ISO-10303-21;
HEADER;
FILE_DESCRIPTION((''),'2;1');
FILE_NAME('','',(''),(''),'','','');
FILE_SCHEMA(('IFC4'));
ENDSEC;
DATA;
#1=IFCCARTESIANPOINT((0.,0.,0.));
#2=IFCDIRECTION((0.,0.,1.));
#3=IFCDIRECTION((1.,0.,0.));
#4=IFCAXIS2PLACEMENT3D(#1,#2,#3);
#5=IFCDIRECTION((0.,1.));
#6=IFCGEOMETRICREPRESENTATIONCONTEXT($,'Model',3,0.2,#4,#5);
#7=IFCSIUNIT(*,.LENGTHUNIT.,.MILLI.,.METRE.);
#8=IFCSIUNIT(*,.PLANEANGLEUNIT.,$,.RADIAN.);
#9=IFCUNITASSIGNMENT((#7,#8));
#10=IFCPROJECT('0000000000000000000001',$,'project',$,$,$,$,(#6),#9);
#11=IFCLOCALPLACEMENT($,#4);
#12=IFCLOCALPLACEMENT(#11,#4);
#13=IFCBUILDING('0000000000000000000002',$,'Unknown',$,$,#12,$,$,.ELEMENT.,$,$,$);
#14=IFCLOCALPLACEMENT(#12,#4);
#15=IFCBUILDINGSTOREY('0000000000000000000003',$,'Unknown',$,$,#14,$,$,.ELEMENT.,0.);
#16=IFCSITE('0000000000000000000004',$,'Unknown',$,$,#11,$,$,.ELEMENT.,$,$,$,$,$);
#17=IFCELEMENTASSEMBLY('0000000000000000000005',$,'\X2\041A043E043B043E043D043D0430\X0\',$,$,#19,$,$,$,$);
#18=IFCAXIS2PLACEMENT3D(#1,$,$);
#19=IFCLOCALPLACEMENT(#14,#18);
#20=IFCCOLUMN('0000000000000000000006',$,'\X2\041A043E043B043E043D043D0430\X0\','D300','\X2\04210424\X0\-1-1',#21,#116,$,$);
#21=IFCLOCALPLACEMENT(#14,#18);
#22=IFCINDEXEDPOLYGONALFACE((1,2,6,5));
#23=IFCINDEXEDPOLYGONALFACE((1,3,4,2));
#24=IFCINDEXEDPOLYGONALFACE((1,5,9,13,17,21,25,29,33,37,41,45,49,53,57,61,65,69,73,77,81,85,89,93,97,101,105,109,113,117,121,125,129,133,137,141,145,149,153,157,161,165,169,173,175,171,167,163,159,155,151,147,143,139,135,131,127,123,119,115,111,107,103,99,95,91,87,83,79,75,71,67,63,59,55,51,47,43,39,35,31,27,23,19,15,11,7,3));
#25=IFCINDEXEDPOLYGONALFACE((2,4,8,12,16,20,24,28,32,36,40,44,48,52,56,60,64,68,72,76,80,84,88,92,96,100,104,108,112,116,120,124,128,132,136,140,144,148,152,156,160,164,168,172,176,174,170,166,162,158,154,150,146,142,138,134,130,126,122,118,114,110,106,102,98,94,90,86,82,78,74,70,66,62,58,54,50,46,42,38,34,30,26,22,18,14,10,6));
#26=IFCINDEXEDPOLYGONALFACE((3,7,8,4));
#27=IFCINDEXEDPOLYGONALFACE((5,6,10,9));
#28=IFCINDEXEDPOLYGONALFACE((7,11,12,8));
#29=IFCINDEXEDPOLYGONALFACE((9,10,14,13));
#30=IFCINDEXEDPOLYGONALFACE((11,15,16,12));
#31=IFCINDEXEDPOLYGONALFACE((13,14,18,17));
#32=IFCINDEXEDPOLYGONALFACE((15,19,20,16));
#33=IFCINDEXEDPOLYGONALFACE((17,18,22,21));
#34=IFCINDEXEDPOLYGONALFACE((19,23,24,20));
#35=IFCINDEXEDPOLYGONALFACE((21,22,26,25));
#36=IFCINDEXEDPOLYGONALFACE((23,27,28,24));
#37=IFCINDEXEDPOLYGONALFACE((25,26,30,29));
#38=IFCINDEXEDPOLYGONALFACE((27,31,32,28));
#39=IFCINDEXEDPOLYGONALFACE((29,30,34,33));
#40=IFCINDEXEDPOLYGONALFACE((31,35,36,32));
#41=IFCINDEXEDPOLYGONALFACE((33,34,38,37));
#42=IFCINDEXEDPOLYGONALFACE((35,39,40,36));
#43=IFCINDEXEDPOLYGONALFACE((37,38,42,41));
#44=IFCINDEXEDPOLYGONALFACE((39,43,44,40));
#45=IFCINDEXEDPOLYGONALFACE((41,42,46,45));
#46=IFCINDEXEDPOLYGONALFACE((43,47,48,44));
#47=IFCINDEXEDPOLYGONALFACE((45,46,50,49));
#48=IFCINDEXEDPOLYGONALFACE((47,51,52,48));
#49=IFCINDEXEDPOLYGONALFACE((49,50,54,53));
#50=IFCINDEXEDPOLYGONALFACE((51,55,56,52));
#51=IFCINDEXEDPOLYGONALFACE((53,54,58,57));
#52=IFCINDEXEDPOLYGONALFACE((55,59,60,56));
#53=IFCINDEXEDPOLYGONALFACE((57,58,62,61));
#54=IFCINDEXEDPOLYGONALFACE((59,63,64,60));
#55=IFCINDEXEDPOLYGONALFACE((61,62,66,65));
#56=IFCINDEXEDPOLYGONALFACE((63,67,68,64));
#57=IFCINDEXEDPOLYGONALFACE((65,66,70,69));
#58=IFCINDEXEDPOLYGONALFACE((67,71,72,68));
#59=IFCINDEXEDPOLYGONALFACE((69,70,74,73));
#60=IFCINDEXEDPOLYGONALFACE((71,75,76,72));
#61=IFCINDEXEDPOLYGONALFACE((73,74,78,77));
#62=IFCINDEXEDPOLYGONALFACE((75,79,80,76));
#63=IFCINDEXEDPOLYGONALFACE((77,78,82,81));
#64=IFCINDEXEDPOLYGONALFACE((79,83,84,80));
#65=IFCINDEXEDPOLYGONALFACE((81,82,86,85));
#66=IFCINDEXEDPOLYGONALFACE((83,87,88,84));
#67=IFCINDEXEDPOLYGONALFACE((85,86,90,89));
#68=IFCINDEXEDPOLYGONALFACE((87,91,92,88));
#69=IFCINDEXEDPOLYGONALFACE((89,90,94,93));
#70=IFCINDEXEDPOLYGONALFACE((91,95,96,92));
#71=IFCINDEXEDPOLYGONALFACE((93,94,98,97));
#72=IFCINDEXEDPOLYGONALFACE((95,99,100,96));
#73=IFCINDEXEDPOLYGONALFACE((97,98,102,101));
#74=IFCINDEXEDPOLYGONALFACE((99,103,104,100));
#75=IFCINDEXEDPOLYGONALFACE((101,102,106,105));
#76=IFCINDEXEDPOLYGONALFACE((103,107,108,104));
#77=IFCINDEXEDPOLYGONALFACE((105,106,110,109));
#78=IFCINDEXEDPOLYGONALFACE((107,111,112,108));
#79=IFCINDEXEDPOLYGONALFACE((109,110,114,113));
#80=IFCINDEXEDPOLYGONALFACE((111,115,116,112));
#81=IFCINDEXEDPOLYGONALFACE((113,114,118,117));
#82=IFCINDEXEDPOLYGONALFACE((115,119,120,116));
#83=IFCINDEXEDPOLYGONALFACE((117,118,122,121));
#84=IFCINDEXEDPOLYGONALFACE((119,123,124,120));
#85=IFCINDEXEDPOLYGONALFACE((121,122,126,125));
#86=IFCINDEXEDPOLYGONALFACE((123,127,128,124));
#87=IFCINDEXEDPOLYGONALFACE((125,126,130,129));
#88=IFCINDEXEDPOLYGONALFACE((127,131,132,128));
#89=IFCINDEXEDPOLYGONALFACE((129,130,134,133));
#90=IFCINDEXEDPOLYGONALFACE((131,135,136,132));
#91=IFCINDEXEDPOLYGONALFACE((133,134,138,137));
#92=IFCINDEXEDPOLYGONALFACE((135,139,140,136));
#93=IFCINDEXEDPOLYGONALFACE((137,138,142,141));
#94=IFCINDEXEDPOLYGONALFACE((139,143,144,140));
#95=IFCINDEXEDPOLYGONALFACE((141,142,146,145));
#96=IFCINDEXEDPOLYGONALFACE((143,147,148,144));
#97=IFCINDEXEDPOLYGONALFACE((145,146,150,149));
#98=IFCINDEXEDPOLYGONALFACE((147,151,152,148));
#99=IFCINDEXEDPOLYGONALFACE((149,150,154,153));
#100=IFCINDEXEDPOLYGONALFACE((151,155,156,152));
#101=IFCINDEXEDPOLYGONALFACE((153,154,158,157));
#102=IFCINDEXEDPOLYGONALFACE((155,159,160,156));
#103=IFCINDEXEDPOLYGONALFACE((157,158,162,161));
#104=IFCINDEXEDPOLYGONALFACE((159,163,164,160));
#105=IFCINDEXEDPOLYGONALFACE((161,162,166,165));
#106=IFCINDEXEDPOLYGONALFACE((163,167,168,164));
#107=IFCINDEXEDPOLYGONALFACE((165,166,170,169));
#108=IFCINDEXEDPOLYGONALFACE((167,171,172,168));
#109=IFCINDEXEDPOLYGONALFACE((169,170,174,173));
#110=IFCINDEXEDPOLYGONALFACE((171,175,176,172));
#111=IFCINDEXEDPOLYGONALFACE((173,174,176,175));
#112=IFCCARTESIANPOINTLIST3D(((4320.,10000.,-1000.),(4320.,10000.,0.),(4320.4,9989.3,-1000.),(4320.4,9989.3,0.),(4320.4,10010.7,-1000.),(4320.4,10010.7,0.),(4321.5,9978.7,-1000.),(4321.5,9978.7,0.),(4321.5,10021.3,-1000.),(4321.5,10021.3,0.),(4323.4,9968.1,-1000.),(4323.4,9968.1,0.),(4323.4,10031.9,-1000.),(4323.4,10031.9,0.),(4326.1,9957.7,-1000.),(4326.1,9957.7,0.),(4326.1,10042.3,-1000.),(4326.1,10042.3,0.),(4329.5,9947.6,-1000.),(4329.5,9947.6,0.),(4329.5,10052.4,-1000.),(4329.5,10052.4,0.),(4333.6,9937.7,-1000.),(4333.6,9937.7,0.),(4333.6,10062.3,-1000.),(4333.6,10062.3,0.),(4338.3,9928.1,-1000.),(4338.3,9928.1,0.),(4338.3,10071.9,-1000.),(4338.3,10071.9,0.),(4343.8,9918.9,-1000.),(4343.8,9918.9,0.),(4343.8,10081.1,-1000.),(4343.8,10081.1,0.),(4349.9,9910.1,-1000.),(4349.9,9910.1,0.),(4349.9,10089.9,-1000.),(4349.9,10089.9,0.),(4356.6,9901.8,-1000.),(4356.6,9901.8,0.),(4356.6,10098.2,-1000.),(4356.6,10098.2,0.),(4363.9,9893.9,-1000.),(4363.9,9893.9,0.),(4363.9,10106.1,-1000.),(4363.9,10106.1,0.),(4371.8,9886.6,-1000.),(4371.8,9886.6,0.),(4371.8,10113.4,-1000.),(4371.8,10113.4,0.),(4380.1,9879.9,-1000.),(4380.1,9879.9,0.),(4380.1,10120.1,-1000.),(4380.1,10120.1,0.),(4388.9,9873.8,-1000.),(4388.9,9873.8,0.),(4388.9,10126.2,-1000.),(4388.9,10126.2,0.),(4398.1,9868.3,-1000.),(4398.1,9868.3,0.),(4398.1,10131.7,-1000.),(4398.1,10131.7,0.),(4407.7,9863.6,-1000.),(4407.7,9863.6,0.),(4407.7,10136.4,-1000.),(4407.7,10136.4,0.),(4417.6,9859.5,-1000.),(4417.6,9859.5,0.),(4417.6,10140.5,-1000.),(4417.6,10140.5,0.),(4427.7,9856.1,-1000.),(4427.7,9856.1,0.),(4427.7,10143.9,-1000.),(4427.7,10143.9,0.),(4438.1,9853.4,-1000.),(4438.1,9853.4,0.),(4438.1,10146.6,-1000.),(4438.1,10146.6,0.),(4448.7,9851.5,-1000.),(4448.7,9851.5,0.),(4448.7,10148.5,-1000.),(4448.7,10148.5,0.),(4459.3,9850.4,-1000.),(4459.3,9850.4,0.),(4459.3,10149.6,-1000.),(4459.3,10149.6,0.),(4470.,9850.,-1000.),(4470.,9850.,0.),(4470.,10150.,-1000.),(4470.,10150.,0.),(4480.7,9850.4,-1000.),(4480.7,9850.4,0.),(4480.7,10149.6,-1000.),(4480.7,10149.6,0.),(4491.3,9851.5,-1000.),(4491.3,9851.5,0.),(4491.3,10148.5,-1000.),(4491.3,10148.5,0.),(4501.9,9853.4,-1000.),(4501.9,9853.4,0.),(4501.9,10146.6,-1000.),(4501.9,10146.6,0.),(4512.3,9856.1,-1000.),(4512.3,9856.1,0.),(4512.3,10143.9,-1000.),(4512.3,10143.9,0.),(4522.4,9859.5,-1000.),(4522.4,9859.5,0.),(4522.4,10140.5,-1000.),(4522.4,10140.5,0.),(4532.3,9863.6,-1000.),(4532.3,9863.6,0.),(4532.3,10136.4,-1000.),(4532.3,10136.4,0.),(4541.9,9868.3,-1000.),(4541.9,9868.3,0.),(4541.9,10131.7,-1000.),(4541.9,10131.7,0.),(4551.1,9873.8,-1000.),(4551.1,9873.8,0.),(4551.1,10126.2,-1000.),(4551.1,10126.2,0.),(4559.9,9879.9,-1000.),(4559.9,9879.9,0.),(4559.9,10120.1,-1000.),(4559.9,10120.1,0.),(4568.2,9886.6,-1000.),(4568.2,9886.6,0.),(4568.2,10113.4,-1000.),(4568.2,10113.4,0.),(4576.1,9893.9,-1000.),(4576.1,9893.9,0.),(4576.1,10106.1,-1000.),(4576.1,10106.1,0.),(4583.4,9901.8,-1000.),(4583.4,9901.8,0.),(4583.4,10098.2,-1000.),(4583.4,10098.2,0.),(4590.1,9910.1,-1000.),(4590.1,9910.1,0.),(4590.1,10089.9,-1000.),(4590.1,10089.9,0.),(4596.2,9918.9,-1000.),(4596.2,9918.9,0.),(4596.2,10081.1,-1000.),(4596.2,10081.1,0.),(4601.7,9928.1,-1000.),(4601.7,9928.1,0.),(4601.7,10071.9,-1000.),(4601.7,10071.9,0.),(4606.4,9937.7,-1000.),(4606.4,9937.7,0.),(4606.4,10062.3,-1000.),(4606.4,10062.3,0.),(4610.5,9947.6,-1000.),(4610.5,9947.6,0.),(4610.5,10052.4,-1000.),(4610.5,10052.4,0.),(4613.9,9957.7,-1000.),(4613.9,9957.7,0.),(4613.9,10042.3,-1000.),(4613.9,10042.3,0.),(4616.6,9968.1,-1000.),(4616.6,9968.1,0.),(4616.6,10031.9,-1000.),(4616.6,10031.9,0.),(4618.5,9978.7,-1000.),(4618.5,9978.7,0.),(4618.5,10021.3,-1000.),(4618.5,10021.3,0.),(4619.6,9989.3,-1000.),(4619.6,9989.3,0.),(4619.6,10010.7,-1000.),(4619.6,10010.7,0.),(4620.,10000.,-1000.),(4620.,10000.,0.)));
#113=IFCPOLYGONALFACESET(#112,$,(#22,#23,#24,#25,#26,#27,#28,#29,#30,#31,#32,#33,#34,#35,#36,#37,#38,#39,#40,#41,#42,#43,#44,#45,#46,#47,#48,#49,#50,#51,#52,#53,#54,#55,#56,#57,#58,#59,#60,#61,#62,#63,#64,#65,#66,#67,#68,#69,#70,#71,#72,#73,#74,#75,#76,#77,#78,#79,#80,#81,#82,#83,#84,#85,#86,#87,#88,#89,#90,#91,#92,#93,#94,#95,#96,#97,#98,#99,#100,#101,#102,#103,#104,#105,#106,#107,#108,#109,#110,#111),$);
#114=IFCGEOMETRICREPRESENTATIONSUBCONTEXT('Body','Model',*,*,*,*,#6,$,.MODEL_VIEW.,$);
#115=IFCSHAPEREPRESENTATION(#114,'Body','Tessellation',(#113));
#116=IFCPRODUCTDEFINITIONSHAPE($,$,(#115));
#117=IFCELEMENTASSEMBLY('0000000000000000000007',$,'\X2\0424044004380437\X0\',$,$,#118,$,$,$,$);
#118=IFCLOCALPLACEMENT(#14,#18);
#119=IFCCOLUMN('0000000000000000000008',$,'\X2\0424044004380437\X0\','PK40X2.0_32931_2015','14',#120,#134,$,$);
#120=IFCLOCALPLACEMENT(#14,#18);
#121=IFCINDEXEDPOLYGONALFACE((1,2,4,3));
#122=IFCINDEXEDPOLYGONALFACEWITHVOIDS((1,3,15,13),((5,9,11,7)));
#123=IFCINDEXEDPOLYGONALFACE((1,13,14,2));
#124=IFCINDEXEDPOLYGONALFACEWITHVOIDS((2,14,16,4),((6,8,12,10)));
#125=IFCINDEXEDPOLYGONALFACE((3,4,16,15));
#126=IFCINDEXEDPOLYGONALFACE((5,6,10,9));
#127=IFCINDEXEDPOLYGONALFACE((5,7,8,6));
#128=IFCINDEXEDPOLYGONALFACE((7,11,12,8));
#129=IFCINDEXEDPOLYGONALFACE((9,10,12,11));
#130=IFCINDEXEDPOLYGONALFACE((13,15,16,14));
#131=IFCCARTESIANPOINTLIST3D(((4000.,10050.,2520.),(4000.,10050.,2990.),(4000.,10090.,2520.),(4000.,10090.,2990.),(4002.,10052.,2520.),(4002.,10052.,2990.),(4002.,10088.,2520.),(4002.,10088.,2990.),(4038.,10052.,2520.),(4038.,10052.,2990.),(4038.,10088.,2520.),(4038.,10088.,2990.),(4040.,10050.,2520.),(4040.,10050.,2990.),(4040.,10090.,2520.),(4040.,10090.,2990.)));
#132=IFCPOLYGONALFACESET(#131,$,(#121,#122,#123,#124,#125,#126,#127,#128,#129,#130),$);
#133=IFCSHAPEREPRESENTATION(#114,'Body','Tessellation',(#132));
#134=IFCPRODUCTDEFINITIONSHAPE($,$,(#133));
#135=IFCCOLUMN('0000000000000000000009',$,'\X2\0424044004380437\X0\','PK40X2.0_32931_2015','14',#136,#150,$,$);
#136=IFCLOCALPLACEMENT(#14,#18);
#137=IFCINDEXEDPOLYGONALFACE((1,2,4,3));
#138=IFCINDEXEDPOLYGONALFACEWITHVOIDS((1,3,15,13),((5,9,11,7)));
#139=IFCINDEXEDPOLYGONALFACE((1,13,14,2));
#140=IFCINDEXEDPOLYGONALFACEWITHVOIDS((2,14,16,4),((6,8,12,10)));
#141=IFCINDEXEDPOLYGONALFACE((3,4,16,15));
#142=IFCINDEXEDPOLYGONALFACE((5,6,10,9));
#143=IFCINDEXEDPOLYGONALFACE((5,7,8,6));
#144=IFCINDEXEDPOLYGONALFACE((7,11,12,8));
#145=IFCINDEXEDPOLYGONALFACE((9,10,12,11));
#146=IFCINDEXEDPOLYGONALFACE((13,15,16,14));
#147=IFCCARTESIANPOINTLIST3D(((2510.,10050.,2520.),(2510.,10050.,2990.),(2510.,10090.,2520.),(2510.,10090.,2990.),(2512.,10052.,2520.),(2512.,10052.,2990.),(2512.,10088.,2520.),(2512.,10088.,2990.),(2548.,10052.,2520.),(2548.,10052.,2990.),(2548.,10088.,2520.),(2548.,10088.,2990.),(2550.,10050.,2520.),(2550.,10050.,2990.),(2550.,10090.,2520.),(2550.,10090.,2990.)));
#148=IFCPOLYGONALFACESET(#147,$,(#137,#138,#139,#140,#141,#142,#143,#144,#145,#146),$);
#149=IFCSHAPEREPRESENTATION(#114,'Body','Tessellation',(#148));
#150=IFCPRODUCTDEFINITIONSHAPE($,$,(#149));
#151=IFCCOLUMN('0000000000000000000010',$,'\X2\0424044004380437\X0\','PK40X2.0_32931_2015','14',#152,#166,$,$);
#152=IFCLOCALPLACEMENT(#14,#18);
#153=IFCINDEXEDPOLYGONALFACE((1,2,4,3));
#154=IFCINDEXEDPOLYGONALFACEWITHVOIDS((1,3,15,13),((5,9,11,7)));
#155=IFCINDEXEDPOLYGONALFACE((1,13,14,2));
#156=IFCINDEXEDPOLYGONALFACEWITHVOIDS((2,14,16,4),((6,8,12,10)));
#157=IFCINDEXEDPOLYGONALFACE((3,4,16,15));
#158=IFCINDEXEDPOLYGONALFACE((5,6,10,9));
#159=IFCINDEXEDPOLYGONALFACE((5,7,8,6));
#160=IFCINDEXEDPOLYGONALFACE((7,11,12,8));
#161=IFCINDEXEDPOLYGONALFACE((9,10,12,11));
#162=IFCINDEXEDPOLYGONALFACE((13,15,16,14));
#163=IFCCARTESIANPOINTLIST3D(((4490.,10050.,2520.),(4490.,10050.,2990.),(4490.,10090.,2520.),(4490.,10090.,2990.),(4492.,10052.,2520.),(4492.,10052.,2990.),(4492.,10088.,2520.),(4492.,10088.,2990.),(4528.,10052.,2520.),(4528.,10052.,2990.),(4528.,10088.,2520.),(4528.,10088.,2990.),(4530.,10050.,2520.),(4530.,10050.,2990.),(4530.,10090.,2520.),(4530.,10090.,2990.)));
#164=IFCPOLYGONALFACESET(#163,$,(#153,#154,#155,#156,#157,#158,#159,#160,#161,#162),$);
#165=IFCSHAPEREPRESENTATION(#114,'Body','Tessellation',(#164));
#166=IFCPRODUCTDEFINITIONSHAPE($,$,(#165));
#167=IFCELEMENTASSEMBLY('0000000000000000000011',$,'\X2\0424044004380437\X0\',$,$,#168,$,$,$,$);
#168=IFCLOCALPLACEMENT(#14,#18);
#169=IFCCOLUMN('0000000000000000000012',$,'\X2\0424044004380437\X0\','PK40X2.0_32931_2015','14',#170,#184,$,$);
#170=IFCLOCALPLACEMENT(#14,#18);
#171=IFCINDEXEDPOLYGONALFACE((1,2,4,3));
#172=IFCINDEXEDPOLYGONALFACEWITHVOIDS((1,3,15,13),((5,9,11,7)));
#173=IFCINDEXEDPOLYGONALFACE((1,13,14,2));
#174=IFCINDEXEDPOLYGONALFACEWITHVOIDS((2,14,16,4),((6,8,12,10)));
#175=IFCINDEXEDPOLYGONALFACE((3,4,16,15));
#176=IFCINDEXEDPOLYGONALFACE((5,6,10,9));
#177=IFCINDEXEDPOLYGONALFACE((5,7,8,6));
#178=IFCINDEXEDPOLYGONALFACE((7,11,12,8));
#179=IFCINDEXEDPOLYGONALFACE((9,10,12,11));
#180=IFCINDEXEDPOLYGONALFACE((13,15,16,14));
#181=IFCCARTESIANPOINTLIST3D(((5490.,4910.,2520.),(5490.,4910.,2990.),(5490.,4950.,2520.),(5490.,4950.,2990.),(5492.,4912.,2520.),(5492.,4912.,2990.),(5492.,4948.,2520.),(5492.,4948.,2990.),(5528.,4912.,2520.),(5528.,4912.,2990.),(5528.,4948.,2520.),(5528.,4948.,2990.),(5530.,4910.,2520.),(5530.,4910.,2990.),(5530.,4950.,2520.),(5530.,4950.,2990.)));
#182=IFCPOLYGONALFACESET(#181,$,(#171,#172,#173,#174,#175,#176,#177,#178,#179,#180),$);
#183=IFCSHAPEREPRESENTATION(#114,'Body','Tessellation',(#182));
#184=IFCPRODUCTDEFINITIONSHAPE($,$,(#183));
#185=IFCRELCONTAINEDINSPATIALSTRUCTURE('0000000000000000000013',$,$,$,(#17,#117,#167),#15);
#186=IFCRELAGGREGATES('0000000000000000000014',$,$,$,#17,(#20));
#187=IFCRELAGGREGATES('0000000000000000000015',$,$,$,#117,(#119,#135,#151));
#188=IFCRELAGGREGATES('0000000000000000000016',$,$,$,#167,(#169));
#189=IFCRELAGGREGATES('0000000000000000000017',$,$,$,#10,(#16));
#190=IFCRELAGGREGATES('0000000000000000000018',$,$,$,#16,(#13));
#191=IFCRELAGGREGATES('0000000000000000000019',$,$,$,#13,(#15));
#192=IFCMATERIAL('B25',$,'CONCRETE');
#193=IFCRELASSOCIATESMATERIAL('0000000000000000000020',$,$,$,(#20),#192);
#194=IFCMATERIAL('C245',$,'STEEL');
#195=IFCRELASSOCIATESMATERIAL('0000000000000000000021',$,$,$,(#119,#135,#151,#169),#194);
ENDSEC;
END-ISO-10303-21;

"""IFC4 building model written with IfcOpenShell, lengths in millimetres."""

from ifc_helpers import new_model, si_unit, direction, frame, origin_with_axes, place, context, subcontext, project, spatial, line, indexed_curve, outline, extrude, material, element, aggregate, save


model = new_model("IFC4")

# Units and contexts
model_context = context("Model", 3, precision=0.2, world=origin_with_axes(), true_north=direction((0.0, 1.0)))
body_context = subcontext(model_context, "Body", "Model", "MODEL_VIEW")
ifc_project = project(units=[si_unit("LENGTHUNIT", "METRE", prefix="MILLI"), si_unit("PLANEANGLEUNIT", "RADIAN")], contexts=[model_context])

# Site, building, storey
site_placement = place(None, origin_with_axes())
site = spatial("IfcSite", under=ifc_project, at=site_placement, Name="Unknown", CompositionType="ELEMENT")
building_placement = place(site_placement, origin_with_axes())
building = spatial("IfcBuilding", under=site, at=building_placement, Name="Unknown", CompositionType="ELEMENT")
storey_placement = place(building_placement, origin_with_axes())
storey = spatial("IfcBuildingStorey", under=building, at=storey_placement, Name="Unknown", CompositionType="ELEMENT", Elevation=0.0)

# Element assembly, column
ifc_material_1 = material(Name="B25", Category="CONCRETE")
assembly_1_placement = place(storey_placement, frame((4470.0, 10000.0, -1000.0), z_axis=(-1.0, 0.0, 0.0), x_axis=(0.0, 0.0, 1.0)))
assembly_1 = element("IfcElementAssembly", 1, at=assembly_1_placement, inside=storey, Name="Колонна")
column_1_placement = place(assembly_1_placement, origin_with_axes())
column_1 = element("IfcColumn", 2, at=column_1_placement, material=ifc_material_1, Name="Колонна", Description="D300", ObjectType="СФ-1-1", context=body_context, shape_type="SolidModel", body=[
    extrude(outline(indexed_curve([(150.0, 0.0), (149.6, 10.7), (148.5, 21.3), (146.6, 31.9), (143.9, 42.3), (140.5, 52.4), (136.4, 62.3), (131.7, 71.9), (126.2, 81.1), (120.1, 89.9), (113.4, 98.2), (106.1, 106.1), (98.2, 113.4), (89.9, 120.1), (81.1, 126.2), (71.9, 131.7), (62.3, 136.4), (52.4, 140.5), (42.3, 143.9), (31.9, 146.6), (21.3, 148.5), (10.7, 149.6), (0.0, 150.0), (-10.7, 149.6), (-21.3, 148.5), (-31.9, 146.6), (-42.3, 143.9), (-52.4, 140.5), (-62.3, 136.4), (-71.9, 131.7), (-81.1, 126.2), (-89.9, 120.1), (-98.2, 113.4), (-106.1, 106.1), (-113.4, 98.2), (-120.1, 89.9), (-126.2, 81.1), (-131.7, 71.9), (-136.4, 62.3), (-140.5, 52.4), (-143.9, 42.3), (-146.6, 31.9), (-148.5, 21.3), (-149.6, 10.7), (-150.0, 0.0), (-149.6, -10.7), (-148.5, -21.3), (-146.6, -31.9), (-143.9, -42.3), (-140.5, -52.4), (-136.4, -62.3), (-131.7, -71.9), (-126.2, -81.1), (-120.1, -89.9), (-113.4, -98.2), (-106.1, -106.1), (-98.2, -113.4), (-89.9, -120.1), (-81.1, -126.2), (-71.9, -131.7), (-62.3, -136.4), (-52.4, -140.5), (-42.3, -143.9), (-31.9, -146.6), (-21.3, -148.5), (-10.7, -149.6), (0.0, -150.0), (10.7, -149.6), (21.3, -148.5), (31.9, -146.6), (42.3, -143.9), (52.4, -140.5), (62.3, -136.4), (71.9, -131.7), (81.1, -126.2), (89.9, -120.1), (98.2, -113.4), (106.1, -106.1), (113.4, -98.2), (120.1, -89.9), (126.2, -81.1), (131.7, -71.9), (136.4, -62.3), (140.5, -52.4), (143.9, -42.3), (146.6, -31.9), (148.5, -21.3), (149.6, -10.7)], segments=[line(1, 2, 3, 4, 5, 6, 7, 8, 9, 10, 11, 12, 13, 14, 15, 16, 17, 18, 19, 20, 21, 22, 23, 24, 25, 26, 27, 28, 29, 30, 31, 32, 33, 34, 35, 36, 37, 38, 39, 40, 41, 42, 43, 44, 45, 46, 47, 48, 49, 50, 51, 52, 53, 54, 55, 56, 57, 58, 59, 60, 61, 62, 63, 64, 65, 66, 67, 68, 69, 70, 71, 72, 73, 74, 75, 76, 77, 78, 79, 80, 81, 82, 83, 84, 85, 86, 87, 88, 1)])), frame((0.0, 0.0, 0.0), z_axis=(-1.0, 0.0, 0.0), x_axis=(0.0, 0.0, 1.0)), (0.0, 0.0, -1.0), 1000.0),
])
aggregate(assembly_1, [column_1])

# Element assembly, columns
assembly_2_placement = place(storey_placement, frame((-470.0, 10070.0, 3010.0), z_axis=(0.0, -1.0, 0.0), x_axis=(1.0, 0.0, 0.0)))
assembly_2 = element("IfcElementAssembly", 3, at=assembly_2_placement, inside=storey, Name="Фриз")
ifc_material_2 = material(Name="C245", Category="STEEL")
column_2_placement = place(assembly_2_placement, frame((4490.0, -490.0, 0.0), z_axis=(0.0, 0.0, -1.0), x_axis=(0.0, 1.0, 0.0)))
column_2 = element("IfcColumn", 4, at=column_2_placement, material=ifc_material_2, Name="Фриз", Description="PK40X2.0_32931_2015", ObjectType="14", context=body_context, shape_type="SolidModel", body=[
    extrude(outline(indexed_curve([(-20.0, -20.0), (20.0, -20.0), (20.0, 20.0), (-20.0, 20.0)], segments=[line(1, 2, 3, 4, 1)]), holes=[indexed_curve([(-18.0, -18.0), (-18.0, 18.0), (18.0, 18.0), (18.0, -18.0)], segments=[line(1, 2, 3, 4, 1)])]), frame((0.0, 0.0, 0.0), z_axis=(-1.0, 0.0, 0.0), x_axis=(0.0, 0.0, 1.0)), (0.0, 0.0, -1.0), 470.0),
])
column_3_placement = place(assembly_2_placement, frame((3000.0, -490.0, 0.0), z_axis=(0.0, 0.0, -1.0), x_axis=(0.0, 1.0, 0.0)))
column_3 = element("IfcColumn", 5, at=column_3_placement, material=ifc_material_2, Name="Фриз", Description="PK40X2.0_32931_2015", ObjectType="14", context=body_context, shape_type="SolidModel", body=[
    extrude(outline(indexed_curve([(-20.0, -20.0), (20.0, -20.0), (20.0, 20.0), (-20.0, 20.0)], segments=[line(1, 2, 3, 4, 1)]), holes=[indexed_curve([(-18.0, -18.0), (-18.0, 18.0), (18.0, 18.0), (18.0, -18.0)], segments=[line(1, 2, 3, 4, 1)])]), frame((0.0, 0.0, 0.0), z_axis=(-1.0, 0.0, 0.0), x_axis=(0.0, 0.0, 1.0)), (0.0, 0.0, -1.0), 470.0),
])
column_4_placement = place(assembly_2_placement, frame((4980.0, -490.0, 0.0), z_axis=(0.0, 0.0, 1.0), x_axis=(0.0, 1.0, 0.0)))
column_4 = element("IfcColumn", 6, at=column_4_placement, material=ifc_material_2, Name="Фриз", Description="PK40X2.0_32931_2015", ObjectType="14", context=body_context, shape_type="SolidModel", body=[
    extrude(outline(indexed_curve([(-20.0, -20.0), (20.0, -20.0), (20.0, 20.0), (-20.0, 20.0)], segments=[line(1, 2, 3, 4, 1)]), holes=[indexed_curve([(-18.0, -18.0), (-18.0, 18.0), (18.0, 18.0), (18.0, -18.0)], segments=[line(1, 2, 3, 4, 1)])]), frame((0.0, 0.0, 0.0), z_axis=(-1.0, 0.0, 0.0), x_axis=(0.0, 0.0, 1.0)), (0.0, 0.0, -1.0), 470.0),
])
aggregate(assembly_2, [column_2, column_3, column_4])

# Element assembly, column
assembly_3_placement = place(storey_placement, frame((5510.0, -500.0, 3010.0), z_axis=(1.0, 0.0, 0.0), x_axis=(0.0, 1.0, 0.0)))
assembly_3 = element("IfcElementAssembly", 7, at=assembly_3_placement, inside=storey, Name="Фриз")
column_5_placement = place(assembly_3_placement, frame((5430.0, -490.0, 0.0), z_axis=(-1.0, 0.0, 0.0), x_axis=(0.0, 1.0, 0.0)))
column_5 = element("IfcColumn", 8, at=column_5_placement, material=ifc_material_2, Name="Фриз", Description="PK40X2.0_32931_2015", ObjectType="14", context=body_context, shape_type="SolidModel", body=[
    extrude(outline(indexed_curve([(-20.0, -20.0), (20.0, -20.0), (20.0, 20.0), (-20.0, 20.0)], segments=[line(1, 2, 3, 4, 1)]), holes=[indexed_curve([(-18.0, -18.0), (-18.0, 18.0), (18.0, 18.0), (18.0, -18.0)], segments=[line(1, 2, 3, 4, 1)])]), frame((0.0, 0.0, 0.0), z_axis=(-1.0, 0.0, 0.0), x_axis=(0.0, 0.0, 1.0)), (0.0, 0.0, -1.0), 470.0),
])
aggregate(assembly_3, [column_5])

save(model, "model.ifc")
